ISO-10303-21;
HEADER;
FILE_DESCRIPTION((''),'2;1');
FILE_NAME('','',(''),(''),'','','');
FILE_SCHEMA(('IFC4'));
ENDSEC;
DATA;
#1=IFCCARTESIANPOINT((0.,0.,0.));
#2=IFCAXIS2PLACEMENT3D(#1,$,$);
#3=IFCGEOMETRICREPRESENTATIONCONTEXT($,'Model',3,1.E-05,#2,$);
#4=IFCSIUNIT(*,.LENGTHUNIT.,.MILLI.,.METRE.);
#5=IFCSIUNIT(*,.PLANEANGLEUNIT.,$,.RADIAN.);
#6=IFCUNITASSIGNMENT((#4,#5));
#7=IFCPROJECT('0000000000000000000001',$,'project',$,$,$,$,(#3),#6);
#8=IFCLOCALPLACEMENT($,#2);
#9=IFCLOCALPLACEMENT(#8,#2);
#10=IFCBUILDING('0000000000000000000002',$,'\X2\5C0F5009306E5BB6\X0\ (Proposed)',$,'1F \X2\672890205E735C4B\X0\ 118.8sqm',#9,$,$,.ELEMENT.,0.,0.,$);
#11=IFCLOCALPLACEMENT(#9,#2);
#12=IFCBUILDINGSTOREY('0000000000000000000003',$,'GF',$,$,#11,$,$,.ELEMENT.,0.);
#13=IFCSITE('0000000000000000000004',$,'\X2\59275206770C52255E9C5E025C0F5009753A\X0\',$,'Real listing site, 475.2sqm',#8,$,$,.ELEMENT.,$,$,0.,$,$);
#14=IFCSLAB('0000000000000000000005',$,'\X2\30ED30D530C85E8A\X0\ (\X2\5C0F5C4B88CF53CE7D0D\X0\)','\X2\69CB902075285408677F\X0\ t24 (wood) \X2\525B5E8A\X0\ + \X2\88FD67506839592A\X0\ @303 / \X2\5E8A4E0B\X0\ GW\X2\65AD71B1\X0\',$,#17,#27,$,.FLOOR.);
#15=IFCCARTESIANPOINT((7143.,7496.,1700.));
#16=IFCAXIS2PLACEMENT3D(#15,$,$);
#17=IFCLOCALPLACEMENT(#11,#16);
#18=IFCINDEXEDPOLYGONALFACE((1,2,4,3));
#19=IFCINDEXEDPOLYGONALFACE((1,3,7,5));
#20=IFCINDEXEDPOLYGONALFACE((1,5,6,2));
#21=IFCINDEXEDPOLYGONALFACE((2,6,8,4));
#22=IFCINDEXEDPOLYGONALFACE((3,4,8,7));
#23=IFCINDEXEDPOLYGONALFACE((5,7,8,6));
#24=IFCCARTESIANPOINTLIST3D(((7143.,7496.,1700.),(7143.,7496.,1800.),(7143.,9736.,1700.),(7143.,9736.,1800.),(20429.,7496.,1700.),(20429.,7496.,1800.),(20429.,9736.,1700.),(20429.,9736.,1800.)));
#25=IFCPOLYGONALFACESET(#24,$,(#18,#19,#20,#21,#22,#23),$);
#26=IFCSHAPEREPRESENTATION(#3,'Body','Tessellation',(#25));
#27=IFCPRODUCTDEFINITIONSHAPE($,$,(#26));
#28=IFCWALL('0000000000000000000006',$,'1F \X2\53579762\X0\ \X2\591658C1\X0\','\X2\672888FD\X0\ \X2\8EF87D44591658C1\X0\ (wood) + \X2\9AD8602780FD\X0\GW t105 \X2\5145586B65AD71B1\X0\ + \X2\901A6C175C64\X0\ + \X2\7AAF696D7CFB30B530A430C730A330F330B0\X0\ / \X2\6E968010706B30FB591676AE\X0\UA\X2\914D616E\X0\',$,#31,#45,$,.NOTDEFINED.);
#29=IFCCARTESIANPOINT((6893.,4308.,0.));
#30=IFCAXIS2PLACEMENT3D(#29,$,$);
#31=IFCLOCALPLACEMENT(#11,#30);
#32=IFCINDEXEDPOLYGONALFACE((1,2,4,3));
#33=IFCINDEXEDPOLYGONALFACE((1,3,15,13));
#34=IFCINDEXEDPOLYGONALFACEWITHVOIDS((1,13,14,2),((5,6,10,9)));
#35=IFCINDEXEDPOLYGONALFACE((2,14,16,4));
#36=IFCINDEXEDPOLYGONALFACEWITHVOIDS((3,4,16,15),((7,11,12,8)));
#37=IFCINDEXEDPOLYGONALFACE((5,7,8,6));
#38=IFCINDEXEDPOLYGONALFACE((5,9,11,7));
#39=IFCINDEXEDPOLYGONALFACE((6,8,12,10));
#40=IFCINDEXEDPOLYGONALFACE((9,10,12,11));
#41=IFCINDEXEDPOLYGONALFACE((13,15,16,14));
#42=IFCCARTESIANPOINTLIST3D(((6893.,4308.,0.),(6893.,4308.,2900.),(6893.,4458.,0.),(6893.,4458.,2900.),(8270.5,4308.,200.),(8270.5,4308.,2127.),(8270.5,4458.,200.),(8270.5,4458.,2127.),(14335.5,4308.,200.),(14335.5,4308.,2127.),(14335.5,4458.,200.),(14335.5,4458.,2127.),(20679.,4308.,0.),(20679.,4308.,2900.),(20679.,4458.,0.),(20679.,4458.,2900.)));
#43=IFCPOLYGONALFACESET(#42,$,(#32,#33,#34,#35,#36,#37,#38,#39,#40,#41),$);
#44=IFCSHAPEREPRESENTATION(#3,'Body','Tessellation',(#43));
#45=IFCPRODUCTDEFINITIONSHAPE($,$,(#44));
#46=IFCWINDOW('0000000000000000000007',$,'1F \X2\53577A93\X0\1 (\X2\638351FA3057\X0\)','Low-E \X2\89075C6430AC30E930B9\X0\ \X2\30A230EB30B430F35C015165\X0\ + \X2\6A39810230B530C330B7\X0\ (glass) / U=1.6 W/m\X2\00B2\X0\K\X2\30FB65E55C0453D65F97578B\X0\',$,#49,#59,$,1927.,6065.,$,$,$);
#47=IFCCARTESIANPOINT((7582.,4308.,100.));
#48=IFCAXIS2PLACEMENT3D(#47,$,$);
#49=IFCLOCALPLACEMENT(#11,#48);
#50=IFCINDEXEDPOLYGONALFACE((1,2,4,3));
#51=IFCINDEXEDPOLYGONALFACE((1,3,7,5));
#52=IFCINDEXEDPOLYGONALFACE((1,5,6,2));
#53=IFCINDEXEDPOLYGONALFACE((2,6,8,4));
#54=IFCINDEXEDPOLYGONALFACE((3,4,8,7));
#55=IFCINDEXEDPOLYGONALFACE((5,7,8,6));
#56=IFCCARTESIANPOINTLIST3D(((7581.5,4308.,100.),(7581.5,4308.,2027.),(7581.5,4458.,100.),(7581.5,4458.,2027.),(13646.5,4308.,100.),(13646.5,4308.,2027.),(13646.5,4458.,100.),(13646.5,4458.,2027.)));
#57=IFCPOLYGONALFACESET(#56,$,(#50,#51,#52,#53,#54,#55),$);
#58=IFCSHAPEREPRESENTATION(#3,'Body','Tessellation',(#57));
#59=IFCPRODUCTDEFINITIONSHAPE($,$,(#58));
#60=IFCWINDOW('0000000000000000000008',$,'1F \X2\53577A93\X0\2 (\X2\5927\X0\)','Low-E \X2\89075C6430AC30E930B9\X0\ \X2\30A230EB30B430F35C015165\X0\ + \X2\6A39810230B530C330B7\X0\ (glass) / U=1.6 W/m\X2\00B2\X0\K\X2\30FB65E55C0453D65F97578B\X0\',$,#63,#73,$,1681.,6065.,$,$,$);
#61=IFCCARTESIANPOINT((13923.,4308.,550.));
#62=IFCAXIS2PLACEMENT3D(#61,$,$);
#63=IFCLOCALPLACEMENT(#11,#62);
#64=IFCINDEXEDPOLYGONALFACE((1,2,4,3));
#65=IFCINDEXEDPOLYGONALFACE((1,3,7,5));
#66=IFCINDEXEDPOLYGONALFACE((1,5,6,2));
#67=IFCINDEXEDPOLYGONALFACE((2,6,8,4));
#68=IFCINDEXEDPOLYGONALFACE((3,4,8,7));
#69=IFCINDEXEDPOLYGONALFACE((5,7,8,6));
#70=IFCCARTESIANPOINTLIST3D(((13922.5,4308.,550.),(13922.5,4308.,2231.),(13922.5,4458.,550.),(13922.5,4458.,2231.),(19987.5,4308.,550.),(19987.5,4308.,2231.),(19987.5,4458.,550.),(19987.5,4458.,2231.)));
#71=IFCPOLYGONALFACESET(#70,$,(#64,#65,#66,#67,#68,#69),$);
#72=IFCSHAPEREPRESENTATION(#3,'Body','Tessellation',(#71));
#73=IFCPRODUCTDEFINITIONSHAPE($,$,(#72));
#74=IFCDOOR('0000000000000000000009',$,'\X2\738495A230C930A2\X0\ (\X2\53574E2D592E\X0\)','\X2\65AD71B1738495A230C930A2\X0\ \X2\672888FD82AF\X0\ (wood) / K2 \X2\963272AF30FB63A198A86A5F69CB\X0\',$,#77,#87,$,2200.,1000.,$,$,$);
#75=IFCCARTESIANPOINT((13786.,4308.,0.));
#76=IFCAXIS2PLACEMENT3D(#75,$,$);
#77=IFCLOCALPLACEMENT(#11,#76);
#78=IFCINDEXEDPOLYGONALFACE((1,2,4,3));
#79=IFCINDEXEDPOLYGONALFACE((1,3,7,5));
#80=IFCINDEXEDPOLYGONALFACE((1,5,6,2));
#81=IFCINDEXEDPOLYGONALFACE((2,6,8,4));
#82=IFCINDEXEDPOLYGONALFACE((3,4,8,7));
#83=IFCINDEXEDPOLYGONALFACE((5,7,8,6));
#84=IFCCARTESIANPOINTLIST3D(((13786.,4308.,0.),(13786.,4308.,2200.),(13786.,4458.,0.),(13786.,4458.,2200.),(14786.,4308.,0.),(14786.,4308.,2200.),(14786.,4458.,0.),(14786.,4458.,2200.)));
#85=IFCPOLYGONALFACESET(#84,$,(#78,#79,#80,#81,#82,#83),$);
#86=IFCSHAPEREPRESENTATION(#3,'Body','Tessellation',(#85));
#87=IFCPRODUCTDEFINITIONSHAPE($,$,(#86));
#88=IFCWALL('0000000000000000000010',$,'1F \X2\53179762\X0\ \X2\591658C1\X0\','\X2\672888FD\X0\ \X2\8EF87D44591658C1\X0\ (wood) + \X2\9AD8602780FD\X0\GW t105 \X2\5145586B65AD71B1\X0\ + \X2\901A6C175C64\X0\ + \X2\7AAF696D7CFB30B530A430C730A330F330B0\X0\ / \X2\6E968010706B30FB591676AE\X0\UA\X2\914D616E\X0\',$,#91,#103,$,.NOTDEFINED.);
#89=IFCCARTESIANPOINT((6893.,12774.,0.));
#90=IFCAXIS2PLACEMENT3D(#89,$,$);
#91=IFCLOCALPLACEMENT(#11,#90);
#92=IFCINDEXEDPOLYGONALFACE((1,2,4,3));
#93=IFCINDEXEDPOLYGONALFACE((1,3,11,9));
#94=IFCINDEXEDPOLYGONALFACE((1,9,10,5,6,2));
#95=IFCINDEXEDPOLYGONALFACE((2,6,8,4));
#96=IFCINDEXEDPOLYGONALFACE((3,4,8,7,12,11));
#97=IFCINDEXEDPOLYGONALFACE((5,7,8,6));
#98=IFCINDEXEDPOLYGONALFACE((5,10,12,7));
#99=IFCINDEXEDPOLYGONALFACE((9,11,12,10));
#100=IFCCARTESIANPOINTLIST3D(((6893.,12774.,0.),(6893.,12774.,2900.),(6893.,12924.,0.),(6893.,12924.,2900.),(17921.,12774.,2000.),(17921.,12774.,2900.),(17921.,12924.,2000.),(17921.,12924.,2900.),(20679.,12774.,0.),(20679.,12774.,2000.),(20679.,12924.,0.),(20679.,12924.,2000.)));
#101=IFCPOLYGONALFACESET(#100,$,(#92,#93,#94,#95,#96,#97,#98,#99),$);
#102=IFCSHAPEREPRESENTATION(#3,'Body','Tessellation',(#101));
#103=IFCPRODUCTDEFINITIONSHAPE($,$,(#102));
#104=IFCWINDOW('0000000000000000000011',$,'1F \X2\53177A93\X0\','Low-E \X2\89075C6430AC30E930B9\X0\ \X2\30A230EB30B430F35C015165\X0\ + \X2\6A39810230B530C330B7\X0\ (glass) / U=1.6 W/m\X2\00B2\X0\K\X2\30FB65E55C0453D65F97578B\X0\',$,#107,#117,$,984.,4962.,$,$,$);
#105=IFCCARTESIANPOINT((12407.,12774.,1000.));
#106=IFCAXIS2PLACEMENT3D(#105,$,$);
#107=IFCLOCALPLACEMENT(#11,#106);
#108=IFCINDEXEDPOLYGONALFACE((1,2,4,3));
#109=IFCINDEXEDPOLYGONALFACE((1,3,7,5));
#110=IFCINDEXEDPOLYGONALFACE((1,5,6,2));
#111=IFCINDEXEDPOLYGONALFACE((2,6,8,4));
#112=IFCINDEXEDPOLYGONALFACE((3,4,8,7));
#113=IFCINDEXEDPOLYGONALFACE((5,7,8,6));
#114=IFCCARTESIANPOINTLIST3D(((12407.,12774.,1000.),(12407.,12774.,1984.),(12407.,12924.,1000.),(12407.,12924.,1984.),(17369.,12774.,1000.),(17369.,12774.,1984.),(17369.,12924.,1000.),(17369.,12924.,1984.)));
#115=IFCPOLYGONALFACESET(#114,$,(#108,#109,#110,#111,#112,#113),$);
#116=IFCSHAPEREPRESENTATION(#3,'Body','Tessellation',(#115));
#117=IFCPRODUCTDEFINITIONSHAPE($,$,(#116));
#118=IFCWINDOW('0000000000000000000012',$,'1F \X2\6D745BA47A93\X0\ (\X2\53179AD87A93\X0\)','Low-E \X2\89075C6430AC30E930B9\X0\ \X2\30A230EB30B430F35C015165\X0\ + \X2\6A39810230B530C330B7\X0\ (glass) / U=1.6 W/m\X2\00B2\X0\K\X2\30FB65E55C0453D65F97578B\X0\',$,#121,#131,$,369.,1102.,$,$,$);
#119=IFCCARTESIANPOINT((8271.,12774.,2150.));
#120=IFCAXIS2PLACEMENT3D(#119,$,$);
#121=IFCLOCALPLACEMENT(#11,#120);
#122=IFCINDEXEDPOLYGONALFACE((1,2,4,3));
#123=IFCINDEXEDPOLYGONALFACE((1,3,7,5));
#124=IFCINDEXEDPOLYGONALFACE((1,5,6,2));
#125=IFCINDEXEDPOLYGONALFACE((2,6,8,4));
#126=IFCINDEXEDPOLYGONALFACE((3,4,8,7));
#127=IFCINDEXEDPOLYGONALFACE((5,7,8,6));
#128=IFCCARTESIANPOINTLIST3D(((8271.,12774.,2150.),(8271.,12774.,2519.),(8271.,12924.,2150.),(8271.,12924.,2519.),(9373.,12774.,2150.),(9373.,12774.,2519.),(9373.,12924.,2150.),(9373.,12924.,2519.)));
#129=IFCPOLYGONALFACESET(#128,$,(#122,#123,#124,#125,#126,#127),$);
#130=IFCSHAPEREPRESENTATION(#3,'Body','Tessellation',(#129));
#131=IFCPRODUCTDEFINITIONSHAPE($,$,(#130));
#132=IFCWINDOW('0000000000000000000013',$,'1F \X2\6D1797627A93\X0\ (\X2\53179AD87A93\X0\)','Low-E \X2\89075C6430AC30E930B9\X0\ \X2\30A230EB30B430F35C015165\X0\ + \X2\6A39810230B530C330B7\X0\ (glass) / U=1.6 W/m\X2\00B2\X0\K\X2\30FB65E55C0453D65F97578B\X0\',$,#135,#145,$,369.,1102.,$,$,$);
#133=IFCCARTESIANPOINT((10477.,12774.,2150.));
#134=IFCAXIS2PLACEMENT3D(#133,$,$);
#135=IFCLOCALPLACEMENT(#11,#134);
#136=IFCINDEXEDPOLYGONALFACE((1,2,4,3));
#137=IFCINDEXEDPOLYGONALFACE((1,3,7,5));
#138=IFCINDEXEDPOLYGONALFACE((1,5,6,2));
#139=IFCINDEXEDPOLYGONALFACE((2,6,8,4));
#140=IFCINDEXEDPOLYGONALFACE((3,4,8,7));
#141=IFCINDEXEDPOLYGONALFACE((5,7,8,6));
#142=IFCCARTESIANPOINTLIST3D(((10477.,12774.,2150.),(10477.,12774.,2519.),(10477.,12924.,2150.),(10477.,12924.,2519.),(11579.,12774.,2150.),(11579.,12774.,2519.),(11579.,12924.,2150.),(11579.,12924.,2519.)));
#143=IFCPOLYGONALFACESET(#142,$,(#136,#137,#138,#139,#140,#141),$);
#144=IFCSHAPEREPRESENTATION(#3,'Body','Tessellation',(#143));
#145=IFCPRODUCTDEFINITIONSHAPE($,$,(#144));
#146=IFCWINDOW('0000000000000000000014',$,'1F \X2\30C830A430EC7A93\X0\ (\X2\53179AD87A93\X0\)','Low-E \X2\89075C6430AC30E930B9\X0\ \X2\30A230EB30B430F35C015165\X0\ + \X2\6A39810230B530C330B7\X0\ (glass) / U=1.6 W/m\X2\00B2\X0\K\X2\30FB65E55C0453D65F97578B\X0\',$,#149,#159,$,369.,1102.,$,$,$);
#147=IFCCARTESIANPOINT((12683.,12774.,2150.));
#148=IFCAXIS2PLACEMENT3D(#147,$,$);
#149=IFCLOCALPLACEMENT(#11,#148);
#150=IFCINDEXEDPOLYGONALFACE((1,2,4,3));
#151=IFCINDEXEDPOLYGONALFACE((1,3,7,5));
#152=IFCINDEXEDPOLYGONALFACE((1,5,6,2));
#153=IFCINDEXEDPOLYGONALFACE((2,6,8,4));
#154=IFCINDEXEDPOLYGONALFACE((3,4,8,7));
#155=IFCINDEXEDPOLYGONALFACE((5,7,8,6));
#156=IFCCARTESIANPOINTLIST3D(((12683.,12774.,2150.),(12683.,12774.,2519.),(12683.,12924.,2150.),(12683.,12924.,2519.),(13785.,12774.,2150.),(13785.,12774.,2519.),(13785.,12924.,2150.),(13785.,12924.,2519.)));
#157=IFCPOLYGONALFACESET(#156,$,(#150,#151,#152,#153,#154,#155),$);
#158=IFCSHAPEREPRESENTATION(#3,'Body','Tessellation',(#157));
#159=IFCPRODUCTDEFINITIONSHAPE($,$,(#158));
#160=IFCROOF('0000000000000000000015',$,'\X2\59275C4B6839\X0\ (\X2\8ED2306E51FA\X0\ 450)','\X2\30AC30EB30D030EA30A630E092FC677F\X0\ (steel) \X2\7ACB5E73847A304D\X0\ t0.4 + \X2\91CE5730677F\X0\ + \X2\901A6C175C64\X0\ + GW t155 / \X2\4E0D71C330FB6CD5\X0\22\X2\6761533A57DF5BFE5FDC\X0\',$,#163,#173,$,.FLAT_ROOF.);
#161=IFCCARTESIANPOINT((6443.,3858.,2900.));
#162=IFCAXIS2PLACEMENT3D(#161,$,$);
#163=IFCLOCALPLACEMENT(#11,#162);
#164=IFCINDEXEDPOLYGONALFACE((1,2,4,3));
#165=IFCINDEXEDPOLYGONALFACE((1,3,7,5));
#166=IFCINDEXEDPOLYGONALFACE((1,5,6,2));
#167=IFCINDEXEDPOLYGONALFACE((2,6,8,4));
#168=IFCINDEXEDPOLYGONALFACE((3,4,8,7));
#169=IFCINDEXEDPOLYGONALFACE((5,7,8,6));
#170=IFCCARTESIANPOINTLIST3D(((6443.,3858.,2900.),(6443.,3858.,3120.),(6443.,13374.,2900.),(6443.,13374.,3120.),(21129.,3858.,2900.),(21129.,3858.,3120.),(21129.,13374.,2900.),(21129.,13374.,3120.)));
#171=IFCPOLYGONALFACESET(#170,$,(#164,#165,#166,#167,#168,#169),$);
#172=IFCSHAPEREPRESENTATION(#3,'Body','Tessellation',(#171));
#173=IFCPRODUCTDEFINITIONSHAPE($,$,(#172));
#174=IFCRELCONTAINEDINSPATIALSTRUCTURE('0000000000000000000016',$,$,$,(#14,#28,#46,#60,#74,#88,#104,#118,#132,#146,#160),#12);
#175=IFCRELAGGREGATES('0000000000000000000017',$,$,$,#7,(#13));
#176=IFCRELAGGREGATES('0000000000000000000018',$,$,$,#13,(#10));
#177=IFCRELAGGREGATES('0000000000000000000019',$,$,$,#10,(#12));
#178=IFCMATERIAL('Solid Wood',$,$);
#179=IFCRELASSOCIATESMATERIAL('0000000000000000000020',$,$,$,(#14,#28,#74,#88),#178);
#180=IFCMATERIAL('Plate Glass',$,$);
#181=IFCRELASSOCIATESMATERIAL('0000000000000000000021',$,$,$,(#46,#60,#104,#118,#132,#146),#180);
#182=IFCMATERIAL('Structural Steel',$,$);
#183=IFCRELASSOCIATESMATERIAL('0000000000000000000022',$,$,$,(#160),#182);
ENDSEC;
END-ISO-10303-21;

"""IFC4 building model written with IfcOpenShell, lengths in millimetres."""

from ifc_helpers import new_model, si_unit, frame, frame_2d, origin, place, context, project, spatial, rectangle, extrude, material, element, fill, save


model = new_model("IFC4")

# Units and contexts
model_context = context("Model", 3, precision=1e-05, world=origin())
ifc_project = project(units=[si_unit("LENGTHUNIT", "METRE", prefix="MILLI"), si_unit("PLANEANGLEUNIT", "RADIAN")], contexts=[model_context])

# Site, building, storey
site_placement = place(None, origin())
site = spatial("IfcSite", under=ifc_project, at=site_placement, Name="大分県別府市小倉町", ObjectType="Real listing site, 475.2sqm", CompositionType="ELEMENT", RefElevation=0.0)
building_placement = place(site_placement, origin())
building = spatial("IfcBuilding", under=site, at=building_placement, Name="小倉の家 (Proposed)", ObjectType="1F 木造平屋 118.8sqm", CompositionType="ELEMENT", ElevationOfRefHeight=0.0, ElevationOfTerrain=0.0)
storey_placement = place(building_placement, origin())
storey = spatial("IfcBuildingStorey", under=building, at=storey_placement, Name="GF", CompositionType="ELEMENT", Elevation=0.0)

# Slab
ifc_material_1 = material(Name="Solid Wood")
slab_1_placement = place(storey_placement, frame((7143.0, 7496.0, 1700.0)))
element("IfcSlab", 1, at=slab_1_placement, inside=storey, material=ifc_material_1, Name="ロフト床 (小屋裏収納)", Description="構造用合板 t24 (wood) 剛床 + 製材根太 @303 / 床下 GW断熱", PredefinedType="FLOOR", context=model_context, shape_type="SweptSolid", body=[
    extrude(rectangle(XDim=13286.0, YDim=2240.0, at=frame_2d((6643.0, 1120.0))), frame((7143.0, 7496.0, 1700.0)), (0.0, 0.0, 1.0), 100.0),
])

# Wall, openings, windows, door
wall_1_placement = place(storey_placement, frame((6893.0, 4308.0, 0.0)))
wall_1 = element("IfcWall", 2, at=wall_1_placement, inside=storey, material=ifc_material_1, Name="1F 南面 外壁", Description="木製 軸組外壁 (wood) + 高性能GW t105 充填断熱 + 通気層 + 窯業系サイディング / 準耐火・外皮UA配慮", PredefinedType="NOTDEFINED", context=model_context, shape_type="SweptSolid", body=[
    extrude(rectangle(XDim=13786.0, YDim=150.0, at=frame_2d((6893.0, 75.0))), frame((6893.0, 4308.0, 0.0)), (0.0, 0.0, 1.0), 2900.0),
])
opening_1_placement = place(storey_placement, frame((7582.0, 4308.0, 100.0)))
opening_1 = element("IfcOpeningElement", 3, at=opening_1_placement, cuts=wall_1, PredefinedType="NOTDEFINED", context=model_context, shape_type="SweptSolid", body=[
    extrude(rectangle(XDim=6065.0, YDim=150.0, at=frame_2d((3032.0, 75.0))), frame((7582.0, 4308.0, 100.0)), (0.0, 0.0, 1.0), 1927.0),
])
opening_2_placement = place(storey_placement, frame((13923.0, 4308.0, 550.0)))
opening_2 = element("IfcOpeningElement", 4, at=opening_2_placement, cuts=wall_1, PredefinedType="NOTDEFINED", context=model_context, shape_type="SweptSolid", body=[
    extrude(rectangle(XDim=6065.0, YDim=150.0, at=frame_2d((3032.0, 75.0))), frame((13923.0, 4308.0, 550.0)), (0.0, 0.0, 1.0), 1681.0),
])
opening_3_placement = place(storey_placement, frame((13786.0, 4308.0, 0.0)))
opening_3 = element("IfcOpeningElement", 5, at=opening_3_placement, cuts=wall_1, PredefinedType="NOTDEFINED", context=model_context, shape_type="SweptSolid", body=[
    extrude(rectangle(XDim=1000.0, YDim=150.0, at=frame_2d((500.0, 75.0))), frame((13786.0, 4308.0, 0.0)), (0.0, 0.0, 1.0), 2200.0),
])
ifc_material_2 = material(Name="Plate Glass")
window_1_placement = place(storey_placement, frame((7582.0, 4308.0, 100.0)))
window_1 = element("IfcWindow", 6, at=window_1_placement, inside=storey, material=ifc_material_2, Name="1F 南窓1 (掃出し)", Description="Low-E 複層ガラス アルゴン封入 + 樹脂サッシ (glass) / U=1.6 W/m²K・日射取得型", OverallHeight=1927.0, OverallWidth=6065.0, context=model_context, shape_type="SweptSolid", body=[
    extrude(rectangle(XDim=6065.0, YDim=150.0, at=frame_2d((3032.0, 75.0))), frame((7582.0, 4308.0, 100.0)), (0.0, 0.0, 1.0), 1927.0),
])
fill(opening_1, window_1)
window_2_placement = place(storey_placement, frame((13923.0, 4308.0, 550.0)))
window_2 = element("IfcWindow", 7, at=window_2_placement, inside=storey, material=ifc_material_2, Name="1F 南窓2 (大)", Description="Low-E 複層ガラス アルゴン封入 + 樹脂サッシ (glass) / U=1.6 W/m²K・日射取得型", OverallHeight=1681.0, OverallWidth=6065.0, context=model_context, shape_type="SweptSolid", body=[
    extrude(rectangle(XDim=6065.0, YDim=150.0, at=frame_2d((3032.0, 75.0))), frame((13923.0, 4308.0, 550.0)), (0.0, 0.0, 1.0), 1681.0),
])
fill(opening_2, window_2)
door_1_placement = place(storey_placement, frame((13786.0, 4308.0, 0.0)))
door_1 = element("IfcDoor", 8, at=door_1_placement, inside=storey, material=ifc_material_1, Name="玄関ドア (南中央)", Description="断熱玄関ドア 木製芯 (wood) / K2 防犯・採風機構", OverallHeight=2200.0, OverallWidth=1000.0, context=model_context, shape_type="SweptSolid", body=[
    extrude(rectangle(XDim=1000.0, YDim=150.0, at=frame_2d((500.0, 75.0))), frame((13786.0, 4308.0, 0.0)), (0.0, 0.0, 1.0), 2200.0),
])
fill(opening_3, door_1)

# Wall, openings, windows
wall_2_placement = place(storey_placement, frame((6893.0, 12774.0, 0.0)))
wall_2 = element("IfcWall", 9, at=wall_2_placement, inside=storey, material=ifc_material_1, Name="1F 北面 外壁", Description="木製 軸組外壁 (wood) + 高性能GW t105 充填断熱 + 通気層 + 窯業系サイディング / 準耐火・外皮UA配慮", PredefinedType="NOTDEFINED", context=model_context, shape_type="SweptSolid", body=[
    extrude(rectangle(XDim=13786.0, YDim=150.0, at=frame_2d((6893.0, 75.0))), frame((6893.0, 12774.0, 0.0)), (0.0, 0.0, 1.0), 2900.0),
])
opening_4_placement = place(storey_placement, frame((12407.0, 12774.0, 1000.0)))
opening_4 = element("IfcOpeningElement", 10, at=opening_4_placement, cuts=wall_2, PredefinedType="NOTDEFINED", context=model_context, shape_type="SweptSolid", body=[
    extrude(rectangle(XDim=4962.0, YDim=150.0, at=frame_2d((2481.0, 75.0))), frame((12407.0, 12774.0, 1000.0)), (0.0, 0.0, 1.0), 984.0),
])
opening_5_placement = place(storey_placement, frame((8271.0, 12774.0, 2150.0)))
opening_5 = element("IfcOpeningElement", 11, at=opening_5_placement, cuts=wall_2, PredefinedType="NOTDEFINED", context=model_context, shape_type="SweptSolid", body=[
    extrude(rectangle(XDim=1102.0, YDim=150.0, at=frame_2d((551.0, 75.0))), frame((8271.0, 12774.0, 2150.0)), (0.0, 0.0, 1.0), 369.0),
])
opening_6_placement = place(storey_placement, frame((10477.0, 12774.0, 2150.0)))
opening_6 = element("IfcOpeningElement", 12, at=opening_6_placement, cuts=wall_2, PredefinedType="NOTDEFINED", context=model_context, shape_type="SweptSolid", body=[
    extrude(rectangle(XDim=1102.0, YDim=150.0, at=frame_2d((551.0, 75.0))), frame((10477.0, 12774.0, 2150.0)), (0.0, 0.0, 1.0), 369.0),
])
opening_7_placement = place(storey_placement, frame((12683.0, 12774.0, 2150.0)))
opening_7 = element("IfcOpeningElement", 13, at=opening_7_placement, cuts=wall_2, PredefinedType="NOTDEFINED", context=model_context, shape_type="SweptSolid", body=[
    extrude(rectangle(XDim=1102.0, YDim=150.0, at=frame_2d((551.0, 75.0))), frame((12683.0, 12774.0, 2150.0)), (0.0, 0.0, 1.0), 369.0),
])
window_3_placement = place(storey_placement, frame((12407.0, 12774.0, 1000.0)))
window_3 = element("IfcWindow", 14, at=window_3_placement, inside=storey, material=ifc_material_2, Name="1F 北窓", Description="Low-E 複層ガラス アルゴン封入 + 樹脂サッシ (glass) / U=1.6 W/m²K・日射取得型", OverallHeight=984.0, OverallWidth=4962.0, context=model_context, shape_type="SweptSolid", body=[
    extrude(rectangle(XDim=4962.0, YDim=150.0, at=frame_2d((2481.0, 75.0))), frame((12407.0, 12774.0, 1000.0)), (0.0, 0.0, 1.0), 984.0),
])
fill(opening_4, window_3)
window_4_placement = place(storey_placement, frame((8271.0, 12774.0, 2150.0)))
window_4 = element("IfcWindow", 15, at=window_4_placement, inside=storey, material=ifc_material_2, Name="1F 浴室窓 (北高窓)", Description="Low-E 複層ガラス アルゴン封入 + 樹脂サッシ (glass) / U=1.6 W/m²K・日射取得型", OverallHeight=369.0, OverallWidth=1102.0, context=model_context, shape_type="SweptSolid", body=[
    extrude(rectangle(XDim=1102.0, YDim=150.0, at=frame_2d((551.0, 75.0))), frame((8271.0, 12774.0, 2150.0)), (0.0, 0.0, 1.0), 369.0),
])
fill(opening_5, window_4)
window_5_placement = place(storey_placement, frame((10477.0, 12774.0, 2150.0)))
window_5 = element("IfcWindow", 16, at=window_5_placement, inside=storey, material=ifc_material_2, Name="1F 洗面窓 (北高窓)", Description="Low-E 複層ガラス アルゴン封入 + 樹脂サッシ (glass) / U=1.6 W/m²K・日射取得型", OverallHeight=369.0, OverallWidth=1102.0, context=model_context, shape_type="SweptSolid", body=[
    extrude(rectangle(XDim=1102.0, YDim=150.0, at=frame_2d((551.0, 75.0))), frame((10477.0, 12774.0, 2150.0)), (0.0, 0.0, 1.0), 369.0),
])
fill(opening_6, window_5)
window_6_placement = place(storey_placement, frame((12683.0, 12774.0, 2150.0)))
window_6 = element("IfcWindow", 17, at=window_6_placement, inside=storey, material=ifc_material_2, Name="1F トイレ窓 (北高窓)", Description="Low-E 複層ガラス アルゴン封入 + 樹脂サッシ (glass) / U=1.6 W/m²K・日射取得型", OverallHeight=369.0, OverallWidth=1102.0, context=model_context, shape_type="SweptSolid", body=[
    extrude(rectangle(XDim=1102.0, YDim=150.0, at=frame_2d((551.0, 75.0))), frame((12683.0, 12774.0, 2150.0)), (0.0, 0.0, 1.0), 369.0),
])
fill(opening_7, window_6)

# Roof
ifc_material_3 = material(Name="Structural Steel")
roof_placement = place(storey_placement, frame((6443.0, 3858.0, 2900.0)))
element("IfcRoof", 18, at=roof_placement, inside=storey, material=ifc_material_3, Name="大屋根 (軒の出 450)", Description="ガルバリウム鋼板 (steel) 立平葺き t0.4 + 野地板 + 通気層 + GW t155 / 不燃・法22条区域対応", PredefinedType="FLAT_ROOF", context=model_context, shape_type="SweptSolid", body=[
    extrude(rectangle(XDim=14686.0, YDim=9516.0, at=frame_2d((7343.0, 4758.0))), frame((6443.0, 3858.0, 2900.0)), (0.0, 0.0, 1.0), 220.0),
])

save(model, "model.ifc")
